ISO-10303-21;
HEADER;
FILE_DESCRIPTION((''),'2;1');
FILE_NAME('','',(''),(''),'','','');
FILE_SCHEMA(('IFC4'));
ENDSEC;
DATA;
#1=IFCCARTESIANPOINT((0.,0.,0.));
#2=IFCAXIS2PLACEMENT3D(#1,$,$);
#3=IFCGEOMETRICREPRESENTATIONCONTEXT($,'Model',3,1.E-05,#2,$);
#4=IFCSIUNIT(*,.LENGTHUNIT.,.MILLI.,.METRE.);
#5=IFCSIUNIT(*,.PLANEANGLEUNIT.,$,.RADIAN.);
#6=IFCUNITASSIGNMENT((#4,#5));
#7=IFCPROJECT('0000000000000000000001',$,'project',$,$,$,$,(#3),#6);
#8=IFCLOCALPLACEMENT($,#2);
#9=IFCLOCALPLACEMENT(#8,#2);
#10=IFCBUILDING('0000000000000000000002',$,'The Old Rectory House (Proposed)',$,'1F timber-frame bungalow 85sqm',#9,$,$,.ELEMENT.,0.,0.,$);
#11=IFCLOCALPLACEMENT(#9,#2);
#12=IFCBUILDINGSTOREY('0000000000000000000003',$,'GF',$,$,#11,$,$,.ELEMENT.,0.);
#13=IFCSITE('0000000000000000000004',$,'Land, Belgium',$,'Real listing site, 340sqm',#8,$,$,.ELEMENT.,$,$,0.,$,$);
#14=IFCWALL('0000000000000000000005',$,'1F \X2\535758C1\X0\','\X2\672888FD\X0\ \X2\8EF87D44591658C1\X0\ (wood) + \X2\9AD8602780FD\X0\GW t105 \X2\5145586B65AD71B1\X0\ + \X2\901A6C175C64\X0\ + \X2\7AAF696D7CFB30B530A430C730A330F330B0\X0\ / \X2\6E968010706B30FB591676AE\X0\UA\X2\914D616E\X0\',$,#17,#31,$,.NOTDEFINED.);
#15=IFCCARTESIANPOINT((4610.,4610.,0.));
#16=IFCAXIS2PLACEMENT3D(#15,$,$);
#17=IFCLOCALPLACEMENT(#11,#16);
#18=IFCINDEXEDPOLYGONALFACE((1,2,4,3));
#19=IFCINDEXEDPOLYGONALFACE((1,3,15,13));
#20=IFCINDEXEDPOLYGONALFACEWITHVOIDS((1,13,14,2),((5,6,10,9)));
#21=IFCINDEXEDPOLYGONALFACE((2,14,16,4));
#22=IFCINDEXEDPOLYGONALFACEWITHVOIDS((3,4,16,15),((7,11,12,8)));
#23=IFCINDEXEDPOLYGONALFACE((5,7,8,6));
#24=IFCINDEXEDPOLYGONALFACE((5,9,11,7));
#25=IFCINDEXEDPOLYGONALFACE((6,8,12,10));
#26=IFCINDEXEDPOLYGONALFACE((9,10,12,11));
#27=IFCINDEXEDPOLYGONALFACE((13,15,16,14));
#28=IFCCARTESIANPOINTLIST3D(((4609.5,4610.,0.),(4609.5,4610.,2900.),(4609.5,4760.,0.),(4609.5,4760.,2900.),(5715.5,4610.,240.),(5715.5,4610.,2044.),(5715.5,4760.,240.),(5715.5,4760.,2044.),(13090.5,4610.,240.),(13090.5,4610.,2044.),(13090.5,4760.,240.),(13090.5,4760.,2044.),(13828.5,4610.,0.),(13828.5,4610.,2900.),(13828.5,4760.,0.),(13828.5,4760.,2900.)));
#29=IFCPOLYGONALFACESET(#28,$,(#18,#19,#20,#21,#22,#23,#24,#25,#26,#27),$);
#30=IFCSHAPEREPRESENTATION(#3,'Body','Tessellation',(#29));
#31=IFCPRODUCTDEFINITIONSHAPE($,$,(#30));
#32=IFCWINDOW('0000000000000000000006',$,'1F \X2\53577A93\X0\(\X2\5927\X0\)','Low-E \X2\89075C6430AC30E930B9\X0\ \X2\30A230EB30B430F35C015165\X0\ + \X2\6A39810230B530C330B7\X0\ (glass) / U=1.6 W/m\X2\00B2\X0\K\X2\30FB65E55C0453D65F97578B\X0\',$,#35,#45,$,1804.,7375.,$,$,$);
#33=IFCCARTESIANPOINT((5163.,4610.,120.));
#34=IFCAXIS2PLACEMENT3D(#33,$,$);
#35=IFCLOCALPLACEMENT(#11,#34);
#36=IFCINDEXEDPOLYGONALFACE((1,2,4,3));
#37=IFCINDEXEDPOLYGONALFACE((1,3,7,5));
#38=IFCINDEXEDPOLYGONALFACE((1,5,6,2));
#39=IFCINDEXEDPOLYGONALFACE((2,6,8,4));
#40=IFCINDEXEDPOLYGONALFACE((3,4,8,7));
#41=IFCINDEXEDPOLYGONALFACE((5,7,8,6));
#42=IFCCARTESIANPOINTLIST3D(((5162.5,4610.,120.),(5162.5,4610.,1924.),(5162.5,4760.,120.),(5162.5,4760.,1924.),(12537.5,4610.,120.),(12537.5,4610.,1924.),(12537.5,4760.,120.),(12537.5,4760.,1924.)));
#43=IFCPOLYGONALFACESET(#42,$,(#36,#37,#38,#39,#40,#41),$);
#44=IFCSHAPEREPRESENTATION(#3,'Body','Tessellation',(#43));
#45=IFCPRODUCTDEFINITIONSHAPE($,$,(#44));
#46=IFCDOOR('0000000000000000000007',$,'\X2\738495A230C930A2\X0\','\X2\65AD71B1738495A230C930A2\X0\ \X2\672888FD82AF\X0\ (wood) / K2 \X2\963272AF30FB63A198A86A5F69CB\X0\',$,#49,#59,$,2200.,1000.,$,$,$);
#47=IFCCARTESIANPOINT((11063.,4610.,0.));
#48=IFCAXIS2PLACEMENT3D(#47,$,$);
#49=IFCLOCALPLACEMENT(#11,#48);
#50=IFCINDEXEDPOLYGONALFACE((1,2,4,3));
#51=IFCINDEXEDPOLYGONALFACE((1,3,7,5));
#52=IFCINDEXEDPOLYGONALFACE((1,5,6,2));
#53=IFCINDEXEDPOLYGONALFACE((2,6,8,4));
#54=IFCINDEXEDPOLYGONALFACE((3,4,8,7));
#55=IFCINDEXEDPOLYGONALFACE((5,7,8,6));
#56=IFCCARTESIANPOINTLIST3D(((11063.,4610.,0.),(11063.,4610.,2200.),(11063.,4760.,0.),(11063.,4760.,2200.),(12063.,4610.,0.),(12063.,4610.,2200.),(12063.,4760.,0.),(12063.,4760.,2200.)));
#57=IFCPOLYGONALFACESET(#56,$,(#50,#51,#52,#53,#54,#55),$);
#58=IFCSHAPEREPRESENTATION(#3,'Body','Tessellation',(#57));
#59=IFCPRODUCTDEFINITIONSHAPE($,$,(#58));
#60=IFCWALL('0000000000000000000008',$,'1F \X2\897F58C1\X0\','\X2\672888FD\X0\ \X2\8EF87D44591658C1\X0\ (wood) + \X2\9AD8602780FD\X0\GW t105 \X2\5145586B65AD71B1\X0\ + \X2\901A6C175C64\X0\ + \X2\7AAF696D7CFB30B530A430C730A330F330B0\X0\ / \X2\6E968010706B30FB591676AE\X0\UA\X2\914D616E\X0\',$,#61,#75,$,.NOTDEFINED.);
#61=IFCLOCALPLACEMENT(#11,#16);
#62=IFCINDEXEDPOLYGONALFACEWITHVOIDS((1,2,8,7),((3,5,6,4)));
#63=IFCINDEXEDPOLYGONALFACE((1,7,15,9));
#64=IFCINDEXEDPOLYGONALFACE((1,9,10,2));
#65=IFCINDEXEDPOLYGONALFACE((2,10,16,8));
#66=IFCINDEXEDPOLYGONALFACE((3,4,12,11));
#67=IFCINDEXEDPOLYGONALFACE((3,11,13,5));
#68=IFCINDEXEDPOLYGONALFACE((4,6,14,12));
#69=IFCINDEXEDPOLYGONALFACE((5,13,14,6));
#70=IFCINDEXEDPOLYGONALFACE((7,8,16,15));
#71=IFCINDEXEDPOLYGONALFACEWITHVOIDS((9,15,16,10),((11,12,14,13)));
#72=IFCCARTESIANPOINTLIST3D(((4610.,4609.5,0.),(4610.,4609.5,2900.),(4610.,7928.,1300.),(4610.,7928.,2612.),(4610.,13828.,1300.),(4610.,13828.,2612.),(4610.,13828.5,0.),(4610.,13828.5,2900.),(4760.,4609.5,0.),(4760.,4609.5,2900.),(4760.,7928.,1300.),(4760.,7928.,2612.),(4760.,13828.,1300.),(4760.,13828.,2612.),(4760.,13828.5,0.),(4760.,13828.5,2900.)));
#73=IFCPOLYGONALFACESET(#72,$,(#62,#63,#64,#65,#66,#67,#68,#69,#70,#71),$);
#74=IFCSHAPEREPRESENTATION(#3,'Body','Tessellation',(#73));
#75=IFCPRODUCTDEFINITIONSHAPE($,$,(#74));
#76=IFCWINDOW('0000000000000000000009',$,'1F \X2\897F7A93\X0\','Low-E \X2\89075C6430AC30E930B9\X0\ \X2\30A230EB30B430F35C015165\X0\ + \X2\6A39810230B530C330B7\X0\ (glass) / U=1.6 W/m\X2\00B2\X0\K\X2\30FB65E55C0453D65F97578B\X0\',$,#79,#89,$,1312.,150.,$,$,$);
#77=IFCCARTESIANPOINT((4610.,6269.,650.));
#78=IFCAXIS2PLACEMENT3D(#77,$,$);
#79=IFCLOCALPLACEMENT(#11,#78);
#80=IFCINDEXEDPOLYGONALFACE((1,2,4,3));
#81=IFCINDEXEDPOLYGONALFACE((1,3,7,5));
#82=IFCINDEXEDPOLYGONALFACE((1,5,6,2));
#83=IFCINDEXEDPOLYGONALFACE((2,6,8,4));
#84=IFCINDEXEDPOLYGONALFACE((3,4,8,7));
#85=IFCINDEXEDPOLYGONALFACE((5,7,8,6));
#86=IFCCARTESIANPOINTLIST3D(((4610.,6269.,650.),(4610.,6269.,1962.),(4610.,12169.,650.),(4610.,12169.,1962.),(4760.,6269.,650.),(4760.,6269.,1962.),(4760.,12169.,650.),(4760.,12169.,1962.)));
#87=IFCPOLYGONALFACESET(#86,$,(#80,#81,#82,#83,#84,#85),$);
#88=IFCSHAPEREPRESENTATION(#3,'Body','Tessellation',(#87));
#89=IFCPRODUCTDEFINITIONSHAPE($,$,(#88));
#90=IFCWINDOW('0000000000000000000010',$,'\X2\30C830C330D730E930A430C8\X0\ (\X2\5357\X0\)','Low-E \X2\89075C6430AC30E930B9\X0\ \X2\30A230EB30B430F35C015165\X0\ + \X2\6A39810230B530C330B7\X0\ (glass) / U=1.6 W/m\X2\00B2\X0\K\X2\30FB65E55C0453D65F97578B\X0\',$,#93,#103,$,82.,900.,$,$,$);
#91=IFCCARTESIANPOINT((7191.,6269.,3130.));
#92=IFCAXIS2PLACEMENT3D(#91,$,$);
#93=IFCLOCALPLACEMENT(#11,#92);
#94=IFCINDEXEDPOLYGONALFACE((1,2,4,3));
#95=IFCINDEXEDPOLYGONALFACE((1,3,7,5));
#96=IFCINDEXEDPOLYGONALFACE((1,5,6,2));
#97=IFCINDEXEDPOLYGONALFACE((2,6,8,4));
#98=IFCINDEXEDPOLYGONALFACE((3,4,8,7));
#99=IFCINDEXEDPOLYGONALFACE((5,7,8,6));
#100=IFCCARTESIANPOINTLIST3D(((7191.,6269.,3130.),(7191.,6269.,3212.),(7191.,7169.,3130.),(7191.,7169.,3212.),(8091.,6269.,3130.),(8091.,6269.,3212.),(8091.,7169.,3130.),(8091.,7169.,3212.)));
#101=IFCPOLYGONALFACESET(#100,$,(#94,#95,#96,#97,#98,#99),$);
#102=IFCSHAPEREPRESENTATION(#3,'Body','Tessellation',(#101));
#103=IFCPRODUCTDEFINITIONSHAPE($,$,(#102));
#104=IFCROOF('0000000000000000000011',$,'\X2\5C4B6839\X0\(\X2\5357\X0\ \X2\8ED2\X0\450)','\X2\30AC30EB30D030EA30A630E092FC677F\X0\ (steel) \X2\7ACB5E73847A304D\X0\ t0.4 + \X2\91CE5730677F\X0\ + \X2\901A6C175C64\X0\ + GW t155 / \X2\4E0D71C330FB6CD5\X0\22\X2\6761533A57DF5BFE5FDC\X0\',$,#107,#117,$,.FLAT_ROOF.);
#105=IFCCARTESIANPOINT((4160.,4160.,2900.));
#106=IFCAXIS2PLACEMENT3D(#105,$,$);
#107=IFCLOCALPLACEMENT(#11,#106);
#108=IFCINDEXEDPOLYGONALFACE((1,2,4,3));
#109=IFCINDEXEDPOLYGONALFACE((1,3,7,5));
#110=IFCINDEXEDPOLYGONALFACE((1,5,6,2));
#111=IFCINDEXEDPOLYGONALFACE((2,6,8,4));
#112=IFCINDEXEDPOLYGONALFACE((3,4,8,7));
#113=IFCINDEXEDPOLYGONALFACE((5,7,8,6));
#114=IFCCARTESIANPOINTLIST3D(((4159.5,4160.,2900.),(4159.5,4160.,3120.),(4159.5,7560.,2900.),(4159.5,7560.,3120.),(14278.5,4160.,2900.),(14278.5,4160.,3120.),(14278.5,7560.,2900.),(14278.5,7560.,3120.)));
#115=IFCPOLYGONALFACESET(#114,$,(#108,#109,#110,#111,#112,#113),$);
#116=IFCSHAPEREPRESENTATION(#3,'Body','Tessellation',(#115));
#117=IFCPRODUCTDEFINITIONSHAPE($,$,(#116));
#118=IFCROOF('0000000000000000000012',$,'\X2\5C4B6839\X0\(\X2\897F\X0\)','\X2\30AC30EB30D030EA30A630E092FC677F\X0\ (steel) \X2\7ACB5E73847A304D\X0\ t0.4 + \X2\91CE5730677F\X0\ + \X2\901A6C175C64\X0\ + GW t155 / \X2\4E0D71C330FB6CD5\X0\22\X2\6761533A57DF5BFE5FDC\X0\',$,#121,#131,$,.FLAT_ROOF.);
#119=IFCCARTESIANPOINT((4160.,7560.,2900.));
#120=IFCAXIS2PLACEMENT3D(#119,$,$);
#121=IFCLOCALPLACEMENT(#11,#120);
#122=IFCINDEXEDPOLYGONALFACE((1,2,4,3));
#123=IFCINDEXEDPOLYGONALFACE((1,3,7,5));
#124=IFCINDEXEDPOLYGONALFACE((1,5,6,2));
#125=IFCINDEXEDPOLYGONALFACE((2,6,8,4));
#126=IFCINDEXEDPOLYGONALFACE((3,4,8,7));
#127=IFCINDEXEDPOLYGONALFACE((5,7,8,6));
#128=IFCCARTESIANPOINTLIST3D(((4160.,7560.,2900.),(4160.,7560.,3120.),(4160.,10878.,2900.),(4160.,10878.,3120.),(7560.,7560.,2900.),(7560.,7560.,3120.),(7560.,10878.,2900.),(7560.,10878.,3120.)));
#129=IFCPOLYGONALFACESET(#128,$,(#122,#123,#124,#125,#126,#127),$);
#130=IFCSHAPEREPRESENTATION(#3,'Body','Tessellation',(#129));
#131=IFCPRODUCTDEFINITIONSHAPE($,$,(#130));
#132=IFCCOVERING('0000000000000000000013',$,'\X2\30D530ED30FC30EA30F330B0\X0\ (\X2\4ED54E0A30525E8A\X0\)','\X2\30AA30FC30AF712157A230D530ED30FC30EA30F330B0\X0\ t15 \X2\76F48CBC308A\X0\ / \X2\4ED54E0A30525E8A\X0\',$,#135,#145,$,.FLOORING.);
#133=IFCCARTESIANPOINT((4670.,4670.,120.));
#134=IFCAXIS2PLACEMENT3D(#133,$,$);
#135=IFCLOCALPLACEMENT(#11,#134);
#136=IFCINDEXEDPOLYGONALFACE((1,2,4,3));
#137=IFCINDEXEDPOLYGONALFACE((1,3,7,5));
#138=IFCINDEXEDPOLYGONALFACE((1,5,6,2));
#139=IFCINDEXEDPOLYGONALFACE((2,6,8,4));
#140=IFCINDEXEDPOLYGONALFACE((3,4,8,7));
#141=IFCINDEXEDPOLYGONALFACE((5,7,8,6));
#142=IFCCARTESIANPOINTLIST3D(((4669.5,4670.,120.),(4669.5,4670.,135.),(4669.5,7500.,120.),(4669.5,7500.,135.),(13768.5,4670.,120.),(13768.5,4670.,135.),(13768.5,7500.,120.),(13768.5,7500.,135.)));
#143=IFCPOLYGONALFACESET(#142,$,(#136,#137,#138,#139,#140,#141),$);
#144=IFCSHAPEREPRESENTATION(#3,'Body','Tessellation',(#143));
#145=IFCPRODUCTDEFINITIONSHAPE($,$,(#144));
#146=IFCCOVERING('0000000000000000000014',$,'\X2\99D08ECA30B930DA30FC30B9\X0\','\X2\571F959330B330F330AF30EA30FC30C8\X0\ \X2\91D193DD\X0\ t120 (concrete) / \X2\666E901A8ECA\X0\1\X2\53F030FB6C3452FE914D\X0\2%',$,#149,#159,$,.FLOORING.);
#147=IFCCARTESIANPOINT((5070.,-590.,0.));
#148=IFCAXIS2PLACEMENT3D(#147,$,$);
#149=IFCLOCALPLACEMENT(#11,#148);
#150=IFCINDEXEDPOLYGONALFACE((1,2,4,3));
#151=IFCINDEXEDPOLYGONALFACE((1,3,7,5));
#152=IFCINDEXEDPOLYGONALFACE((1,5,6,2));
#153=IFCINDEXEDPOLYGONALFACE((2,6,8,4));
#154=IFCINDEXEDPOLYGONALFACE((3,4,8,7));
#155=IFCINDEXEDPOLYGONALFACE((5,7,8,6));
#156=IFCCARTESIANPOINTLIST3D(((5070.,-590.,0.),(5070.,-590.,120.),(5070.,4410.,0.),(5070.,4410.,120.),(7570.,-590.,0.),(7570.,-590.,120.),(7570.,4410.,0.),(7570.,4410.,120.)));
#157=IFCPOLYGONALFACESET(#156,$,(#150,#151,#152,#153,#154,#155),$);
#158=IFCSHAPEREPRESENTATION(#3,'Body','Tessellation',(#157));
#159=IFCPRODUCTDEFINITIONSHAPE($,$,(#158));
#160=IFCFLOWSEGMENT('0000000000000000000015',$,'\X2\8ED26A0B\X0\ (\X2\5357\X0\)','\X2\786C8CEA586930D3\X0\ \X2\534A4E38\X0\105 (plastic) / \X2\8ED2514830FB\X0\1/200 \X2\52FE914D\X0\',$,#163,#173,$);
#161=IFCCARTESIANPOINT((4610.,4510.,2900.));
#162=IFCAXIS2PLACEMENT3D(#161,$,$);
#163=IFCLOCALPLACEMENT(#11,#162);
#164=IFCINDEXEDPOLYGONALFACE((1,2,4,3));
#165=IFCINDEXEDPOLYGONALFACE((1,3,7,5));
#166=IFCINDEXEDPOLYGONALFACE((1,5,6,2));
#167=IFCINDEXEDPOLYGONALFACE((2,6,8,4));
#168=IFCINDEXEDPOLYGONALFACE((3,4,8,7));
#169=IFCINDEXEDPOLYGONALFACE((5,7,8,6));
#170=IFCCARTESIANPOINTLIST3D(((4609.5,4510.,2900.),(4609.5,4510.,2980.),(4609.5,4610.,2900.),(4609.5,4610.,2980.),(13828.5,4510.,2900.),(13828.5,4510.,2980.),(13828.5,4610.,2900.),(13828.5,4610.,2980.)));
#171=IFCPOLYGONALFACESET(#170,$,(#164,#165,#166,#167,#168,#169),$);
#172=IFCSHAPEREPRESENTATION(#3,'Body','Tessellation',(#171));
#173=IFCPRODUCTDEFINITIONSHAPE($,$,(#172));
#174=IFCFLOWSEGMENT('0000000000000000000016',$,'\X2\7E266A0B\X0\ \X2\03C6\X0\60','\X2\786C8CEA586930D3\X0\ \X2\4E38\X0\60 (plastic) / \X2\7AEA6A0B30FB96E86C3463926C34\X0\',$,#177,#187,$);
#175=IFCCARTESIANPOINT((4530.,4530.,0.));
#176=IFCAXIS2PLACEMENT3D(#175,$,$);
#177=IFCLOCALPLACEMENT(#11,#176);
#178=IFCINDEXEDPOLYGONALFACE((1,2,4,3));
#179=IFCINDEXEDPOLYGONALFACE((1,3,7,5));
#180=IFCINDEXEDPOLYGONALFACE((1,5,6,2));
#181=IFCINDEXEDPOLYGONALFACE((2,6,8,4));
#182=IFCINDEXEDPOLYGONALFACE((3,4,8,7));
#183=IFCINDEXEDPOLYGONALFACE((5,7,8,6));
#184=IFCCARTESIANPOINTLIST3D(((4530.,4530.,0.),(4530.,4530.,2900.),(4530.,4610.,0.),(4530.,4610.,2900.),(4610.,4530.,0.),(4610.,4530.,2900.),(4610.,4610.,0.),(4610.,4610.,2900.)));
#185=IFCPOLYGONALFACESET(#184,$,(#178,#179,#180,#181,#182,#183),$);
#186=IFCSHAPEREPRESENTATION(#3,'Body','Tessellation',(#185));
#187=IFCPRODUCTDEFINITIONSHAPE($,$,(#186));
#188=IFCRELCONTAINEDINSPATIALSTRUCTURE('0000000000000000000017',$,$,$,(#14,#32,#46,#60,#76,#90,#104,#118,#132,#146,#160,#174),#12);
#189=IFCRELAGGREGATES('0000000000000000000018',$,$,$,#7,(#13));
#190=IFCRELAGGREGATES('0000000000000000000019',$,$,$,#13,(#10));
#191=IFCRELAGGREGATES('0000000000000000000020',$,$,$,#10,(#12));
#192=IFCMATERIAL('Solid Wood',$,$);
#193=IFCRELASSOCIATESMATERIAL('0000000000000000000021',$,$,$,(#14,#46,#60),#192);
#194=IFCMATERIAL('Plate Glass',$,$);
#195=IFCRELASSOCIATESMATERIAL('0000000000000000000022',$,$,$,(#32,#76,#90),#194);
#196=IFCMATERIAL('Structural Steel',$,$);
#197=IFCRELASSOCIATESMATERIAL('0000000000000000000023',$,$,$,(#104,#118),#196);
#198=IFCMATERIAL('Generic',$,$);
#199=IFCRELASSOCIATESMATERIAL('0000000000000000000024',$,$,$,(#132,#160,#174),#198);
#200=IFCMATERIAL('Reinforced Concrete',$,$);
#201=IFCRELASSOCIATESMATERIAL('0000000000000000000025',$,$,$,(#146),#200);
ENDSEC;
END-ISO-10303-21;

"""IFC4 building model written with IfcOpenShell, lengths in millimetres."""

from ifc_helpers import new_model, si_unit, frame, frame_2d, origin, place, context, project, spatial, rectangle, extrude, material, element, fill, save


model = new_model("IFC4")

# Units and contexts
model_context = context("Model", 3, precision=1e-05, world=origin())
ifc_project = project(units=[si_unit("LENGTHUNIT", "METRE", prefix="MILLI"), si_unit("PLANEANGLEUNIT", "RADIAN")], contexts=[model_context])

# Site, building, storey
site_placement = place(None, origin())
site = spatial("IfcSite", under=ifc_project, at=site_placement, Name="Land, Belgium", ObjectType="Real listing site, 340sqm", CompositionType="ELEMENT", RefElevation=0.0)
building_placement = place(site_placement, origin())
building = spatial("IfcBuilding", under=site, at=building_placement, Name="The Old Rectory House (Proposed)", ObjectType="1F timber-frame bungalow 85sqm", CompositionType="ELEMENT", ElevationOfRefHeight=0.0, ElevationOfTerrain=0.0)
storey_placement = place(building_placement, origin())
storey = spatial("IfcBuildingStorey", under=building, at=storey_placement, Name="GF", CompositionType="ELEMENT", Elevation=0.0)

# Shared definitions
ifc_material_1 = material(Name="Solid Wood")

# Shared definitions
ifc_material_2 = material(Name="Reinforced Concrete")

# Wall, openings, window, door
wall_1_placement = place(storey_placement, frame((4610.0, 4610.0, 0.0)))
wall_1 = element("IfcWall", 1, at=wall_1_placement, inside=storey, material=ifc_material_1, Name="1F 南壁", Description="木製 軸組外壁 (wood) + 高性能GW t105 充填断熱 + 通気層 + 窯業系サイディング / 準耐火・外皮UA配慮", PredefinedType="NOTDEFINED", context=model_context, shape_type="SweptSolid", body=[
    extrude(rectangle(XDim=9219.0, YDim=150.0, at=frame_2d((4609.0, 75.0))), frame((4610.0, 4610.0, 0.0)), (0.0, 0.0, 1.0), 2900.0),
])
opening_1_placement = place(storey_placement, frame((5163.0, 4610.0, 120.0)))
opening_1 = element("IfcOpeningElement", 2, at=opening_1_placement, cuts=wall_1, PredefinedType="NOTDEFINED", context=model_context, shape_type="SweptSolid", body=[
    extrude(rectangle(XDim=7375.0, YDim=150.0, at=frame_2d((3687.0, 75.0))), frame((5163.0, 4610.0, 120.0)), (0.0, 0.0, 1.0), 1804.0),
])
opening_2_placement = place(storey_placement, frame((11063.0, 4610.0, 0.0)))
opening_2 = element("IfcOpeningElement", 3, at=opening_2_placement, cuts=wall_1, PredefinedType="NOTDEFINED", context=model_context, shape_type="SweptSolid", body=[
    extrude(rectangle(XDim=1000.0, YDim=150.0, at=frame_2d((500.0, 75.0))), frame((11063.0, 4610.0, 0.0)), (0.0, 0.0, 1.0), 2200.0),
])
ifc_material_3 = material(Name="Plate Glass")
window_1_placement = place(storey_placement, frame((5163.0, 4610.0, 120.0)))
window_1 = element("IfcWindow", 4, at=window_1_placement, inside=storey, material=ifc_material_3, Name="1F 南窓(大)", Description="Low-E 複層ガラス アルゴン封入 + 樹脂サッシ (glass) / U=1.6 W/m²K・日射取得型", OverallHeight=1804.0, OverallWidth=7375.0, context=model_context, shape_type="SweptSolid", body=[
    extrude(rectangle(XDim=7375.0, YDim=150.0, at=frame_2d((3687.0, 75.0))), frame((5163.0, 4610.0, 120.0)), (0.0, 0.0, 1.0), 1804.0),
])
fill(opening_1, window_1)
door_placement = place(storey_placement, frame((11063.0, 4610.0, 0.0)))
door = element("IfcDoor", 5, at=door_placement, inside=storey, material=ifc_material_1, Name="玄関ドア", Description="断熱玄関ドア 木製芯 (wood) / K2 防犯・採風機構", OverallHeight=2200.0, OverallWidth=1000.0, context=model_context, shape_type="SweptSolid", body=[
    extrude(rectangle(XDim=1000.0, YDim=150.0, at=frame_2d((500.0, 75.0))), frame((11063.0, 4610.0, 0.0)), (0.0, 0.0, 1.0), 2200.0),
])
fill(opening_2, door)

# Wall, opening, window
wall_2_placement = place(storey_placement, frame((4610.0, 4610.0, 0.0)))
wall_2 = element("IfcWall", 6, at=wall_2_placement, inside=storey, material=ifc_material_1, Name="1F 西壁", Description="木製 軸組外壁 (wood) + 高性能GW t105 充填断熱 + 通気層 + 窯業系サイディング / 準耐火・外皮UA配慮", PredefinedType="NOTDEFINED", context=model_context, shape_type="SweptSolid", body=[
    extrude(rectangle(XDim=150.0, YDim=9219.0, at=frame_2d((75.0, 4609.0))), frame((4610.0, 4610.0, 0.0)), (0.0, 0.0, 1.0), 2900.0),
])
opening_3_placement = place(storey_placement, frame((4610.0, 6269.0, 650.0)))
opening_3 = element("IfcOpeningElement", 7, at=opening_3_placement, cuts=wall_2, PredefinedType="NOTDEFINED", context=model_context, shape_type="SweptSolid", body=[
    extrude(rectangle(XDim=150.0, YDim=5900.0, at=frame_2d((75.0, 2950.0))), frame((4610.0, 6269.0, 650.0)), (0.0, 0.0, 1.0), 1312.0),
])
window_2_placement = place(storey_placement, frame((4610.0, 6269.0, 650.0)))
window_2 = element("IfcWindow", 8, at=window_2_placement, inside=storey, material=ifc_material_3, Name="1F 西窓", Description="Low-E 複層ガラス アルゴン封入 + 樹脂サッシ (glass) / U=1.6 W/m²K・日射取得型", OverallHeight=1312.0, OverallWidth=150.0, context=model_context, shape_type="SweptSolid", body=[
    extrude(rectangle(XDim=150.0, YDim=5900.0, at=frame_2d((75.0, 2950.0))), frame((4610.0, 6269.0, 650.0)), (0.0, 0.0, 1.0), 1312.0),
])
fill(opening_3, window_2)

# Window
window_3_placement = place(storey_placement, frame((7191.0, 6269.0, 3130.0)))
element("IfcWindow", 9, at=window_3_placement, inside=storey, material=ifc_material_3, Name="トップライト (南)", Description="Low-E 複層ガラス アルゴン封入 + 樹脂サッシ (glass) / U=1.6 W/m²K・日射取得型", OverallHeight=82.0, OverallWidth=900.0, context=model_context, shape_type="SweptSolid", body=[
    extrude(rectangle(XDim=900.0, YDim=900.0, at=frame_2d((450.0, 450.0))), frame((7191.0, 6269.0, 3130.0)), (0.0, 0.0, 1.0), 82.0),
])

# Roofs
ifc_material_4 = material(Name="Structural Steel")
roof_1_placement = place(storey_placement, frame((4160.0, 4160.0, 2900.0)))
element("IfcRoof", 10, at=roof_1_placement, inside=storey, material=ifc_material_4, Name="屋根(南 軒450)", Description="ガルバリウム鋼板 (steel) 立平葺き t0.4 + 野地板 + 通気層 + GW t155 / 不燃・法22条区域対応", PredefinedType="FLAT_ROOF", context=model_context, shape_type="SweptSolid", body=[
    extrude(rectangle(XDim=10119.0, YDim=3400.0, at=frame_2d((5059.0, 1700.0))), frame((4160.0, 4160.0, 2900.0)), (0.0, 0.0, 1.0), 220.0),
])
roof_2_placement = place(storey_placement, frame((4160.0, 7560.0, 2900.0)))
element("IfcRoof", 11, at=roof_2_placement, inside=storey, material=ifc_material_4, Name="屋根(西)", Description="ガルバリウム鋼板 (steel) 立平葺き t0.4 + 野地板 + 通気層 + GW t155 / 不燃・法22条区域対応", PredefinedType="FLAT_ROOF", context=model_context, shape_type="SweptSolid", body=[
    extrude(rectangle(XDim=3400.0, YDim=3318.0, at=frame_2d((1700.0, 1659.0))), frame((4160.0, 7560.0, 2900.0)), (0.0, 0.0, 1.0), 220.0),
])

# Coverings
ifc_material_5 = material(Name="Generic")
covering_1_placement = place(storey_placement, frame((4670.0, 4670.0, 120.0)))
element("IfcCovering", 12, at=covering_1_placement, inside=storey, material=ifc_material_5, Name="フローリング (仕上げ床)", Description="オーク無垢フローリング t15 直貼り / 仕上げ床", PredefinedType="FLOORING", context=model_context, shape_type="SweptSolid", body=[
    extrude(rectangle(XDim=9099.0, YDim=2830.0, at=frame_2d((4549.0, 1415.0))), frame((4670.0, 4670.0, 120.0)), (0.0, 0.0, 1.0), 15.0),
])
covering_2_placement = place(storey_placement, frame((5070.0, -590.0, 0.0)))
element("IfcCovering", 13, at=covering_2_placement, inside=storey, material=ifc_material_2, Name="駐車スペース", Description="土間コンクリート 金鏝 t120 (concrete) / 普通車1台・水勾配2%", PredefinedType="FLOORING", context=model_context, shape_type="SweptSolid", body=[
    extrude(rectangle(XDim=2500.0, YDim=5000.0, at=frame_2d((1250.0, 2500.0))), frame((5070.0, -590.0, 0.0)), (0.0, 0.0, 1.0), 120.0),
])

# Flow segments
flow_segment_1_placement = place(storey_placement, frame((4610.0, 4510.0, 2900.0)))
element("IfcFlowSegment", 14, at=flow_segment_1_placement, inside=storey, material=ifc_material_5, Name="軒樋 (南)", Description="硬質塩ビ 半丸105 (plastic) / 軒先・1/200 勾配", context=model_context, shape_type="SweptSolid", body=[
    extrude(rectangle(XDim=9219.0, YDim=100.0, at=frame_2d((4609.0, 50.0))), frame((4610.0, 4510.0, 2900.0)), (0.0, 0.0, 1.0), 80.0),
])
flow_segment_2_placement = place(storey_placement, frame((4530.0, 4530.0, 0.0)))
element("IfcFlowSegment", 15, at=flow_segment_2_placement, inside=storey, material=ifc_material_5, Name="縦樋 φ60", Description="硬質塩ビ 丸60 (plastic) / 竪樋・雨水排水", context=model_context, shape_type="SweptSolid", body=[
    extrude(rectangle(XDim=80.0, YDim=80.0, at=frame_2d((40.0, 40.0))), frame((4530.0, 4530.0, 0.0)), (0.0, 0.0, 1.0), 2900.0),
])

save(model, "model.ifc")
